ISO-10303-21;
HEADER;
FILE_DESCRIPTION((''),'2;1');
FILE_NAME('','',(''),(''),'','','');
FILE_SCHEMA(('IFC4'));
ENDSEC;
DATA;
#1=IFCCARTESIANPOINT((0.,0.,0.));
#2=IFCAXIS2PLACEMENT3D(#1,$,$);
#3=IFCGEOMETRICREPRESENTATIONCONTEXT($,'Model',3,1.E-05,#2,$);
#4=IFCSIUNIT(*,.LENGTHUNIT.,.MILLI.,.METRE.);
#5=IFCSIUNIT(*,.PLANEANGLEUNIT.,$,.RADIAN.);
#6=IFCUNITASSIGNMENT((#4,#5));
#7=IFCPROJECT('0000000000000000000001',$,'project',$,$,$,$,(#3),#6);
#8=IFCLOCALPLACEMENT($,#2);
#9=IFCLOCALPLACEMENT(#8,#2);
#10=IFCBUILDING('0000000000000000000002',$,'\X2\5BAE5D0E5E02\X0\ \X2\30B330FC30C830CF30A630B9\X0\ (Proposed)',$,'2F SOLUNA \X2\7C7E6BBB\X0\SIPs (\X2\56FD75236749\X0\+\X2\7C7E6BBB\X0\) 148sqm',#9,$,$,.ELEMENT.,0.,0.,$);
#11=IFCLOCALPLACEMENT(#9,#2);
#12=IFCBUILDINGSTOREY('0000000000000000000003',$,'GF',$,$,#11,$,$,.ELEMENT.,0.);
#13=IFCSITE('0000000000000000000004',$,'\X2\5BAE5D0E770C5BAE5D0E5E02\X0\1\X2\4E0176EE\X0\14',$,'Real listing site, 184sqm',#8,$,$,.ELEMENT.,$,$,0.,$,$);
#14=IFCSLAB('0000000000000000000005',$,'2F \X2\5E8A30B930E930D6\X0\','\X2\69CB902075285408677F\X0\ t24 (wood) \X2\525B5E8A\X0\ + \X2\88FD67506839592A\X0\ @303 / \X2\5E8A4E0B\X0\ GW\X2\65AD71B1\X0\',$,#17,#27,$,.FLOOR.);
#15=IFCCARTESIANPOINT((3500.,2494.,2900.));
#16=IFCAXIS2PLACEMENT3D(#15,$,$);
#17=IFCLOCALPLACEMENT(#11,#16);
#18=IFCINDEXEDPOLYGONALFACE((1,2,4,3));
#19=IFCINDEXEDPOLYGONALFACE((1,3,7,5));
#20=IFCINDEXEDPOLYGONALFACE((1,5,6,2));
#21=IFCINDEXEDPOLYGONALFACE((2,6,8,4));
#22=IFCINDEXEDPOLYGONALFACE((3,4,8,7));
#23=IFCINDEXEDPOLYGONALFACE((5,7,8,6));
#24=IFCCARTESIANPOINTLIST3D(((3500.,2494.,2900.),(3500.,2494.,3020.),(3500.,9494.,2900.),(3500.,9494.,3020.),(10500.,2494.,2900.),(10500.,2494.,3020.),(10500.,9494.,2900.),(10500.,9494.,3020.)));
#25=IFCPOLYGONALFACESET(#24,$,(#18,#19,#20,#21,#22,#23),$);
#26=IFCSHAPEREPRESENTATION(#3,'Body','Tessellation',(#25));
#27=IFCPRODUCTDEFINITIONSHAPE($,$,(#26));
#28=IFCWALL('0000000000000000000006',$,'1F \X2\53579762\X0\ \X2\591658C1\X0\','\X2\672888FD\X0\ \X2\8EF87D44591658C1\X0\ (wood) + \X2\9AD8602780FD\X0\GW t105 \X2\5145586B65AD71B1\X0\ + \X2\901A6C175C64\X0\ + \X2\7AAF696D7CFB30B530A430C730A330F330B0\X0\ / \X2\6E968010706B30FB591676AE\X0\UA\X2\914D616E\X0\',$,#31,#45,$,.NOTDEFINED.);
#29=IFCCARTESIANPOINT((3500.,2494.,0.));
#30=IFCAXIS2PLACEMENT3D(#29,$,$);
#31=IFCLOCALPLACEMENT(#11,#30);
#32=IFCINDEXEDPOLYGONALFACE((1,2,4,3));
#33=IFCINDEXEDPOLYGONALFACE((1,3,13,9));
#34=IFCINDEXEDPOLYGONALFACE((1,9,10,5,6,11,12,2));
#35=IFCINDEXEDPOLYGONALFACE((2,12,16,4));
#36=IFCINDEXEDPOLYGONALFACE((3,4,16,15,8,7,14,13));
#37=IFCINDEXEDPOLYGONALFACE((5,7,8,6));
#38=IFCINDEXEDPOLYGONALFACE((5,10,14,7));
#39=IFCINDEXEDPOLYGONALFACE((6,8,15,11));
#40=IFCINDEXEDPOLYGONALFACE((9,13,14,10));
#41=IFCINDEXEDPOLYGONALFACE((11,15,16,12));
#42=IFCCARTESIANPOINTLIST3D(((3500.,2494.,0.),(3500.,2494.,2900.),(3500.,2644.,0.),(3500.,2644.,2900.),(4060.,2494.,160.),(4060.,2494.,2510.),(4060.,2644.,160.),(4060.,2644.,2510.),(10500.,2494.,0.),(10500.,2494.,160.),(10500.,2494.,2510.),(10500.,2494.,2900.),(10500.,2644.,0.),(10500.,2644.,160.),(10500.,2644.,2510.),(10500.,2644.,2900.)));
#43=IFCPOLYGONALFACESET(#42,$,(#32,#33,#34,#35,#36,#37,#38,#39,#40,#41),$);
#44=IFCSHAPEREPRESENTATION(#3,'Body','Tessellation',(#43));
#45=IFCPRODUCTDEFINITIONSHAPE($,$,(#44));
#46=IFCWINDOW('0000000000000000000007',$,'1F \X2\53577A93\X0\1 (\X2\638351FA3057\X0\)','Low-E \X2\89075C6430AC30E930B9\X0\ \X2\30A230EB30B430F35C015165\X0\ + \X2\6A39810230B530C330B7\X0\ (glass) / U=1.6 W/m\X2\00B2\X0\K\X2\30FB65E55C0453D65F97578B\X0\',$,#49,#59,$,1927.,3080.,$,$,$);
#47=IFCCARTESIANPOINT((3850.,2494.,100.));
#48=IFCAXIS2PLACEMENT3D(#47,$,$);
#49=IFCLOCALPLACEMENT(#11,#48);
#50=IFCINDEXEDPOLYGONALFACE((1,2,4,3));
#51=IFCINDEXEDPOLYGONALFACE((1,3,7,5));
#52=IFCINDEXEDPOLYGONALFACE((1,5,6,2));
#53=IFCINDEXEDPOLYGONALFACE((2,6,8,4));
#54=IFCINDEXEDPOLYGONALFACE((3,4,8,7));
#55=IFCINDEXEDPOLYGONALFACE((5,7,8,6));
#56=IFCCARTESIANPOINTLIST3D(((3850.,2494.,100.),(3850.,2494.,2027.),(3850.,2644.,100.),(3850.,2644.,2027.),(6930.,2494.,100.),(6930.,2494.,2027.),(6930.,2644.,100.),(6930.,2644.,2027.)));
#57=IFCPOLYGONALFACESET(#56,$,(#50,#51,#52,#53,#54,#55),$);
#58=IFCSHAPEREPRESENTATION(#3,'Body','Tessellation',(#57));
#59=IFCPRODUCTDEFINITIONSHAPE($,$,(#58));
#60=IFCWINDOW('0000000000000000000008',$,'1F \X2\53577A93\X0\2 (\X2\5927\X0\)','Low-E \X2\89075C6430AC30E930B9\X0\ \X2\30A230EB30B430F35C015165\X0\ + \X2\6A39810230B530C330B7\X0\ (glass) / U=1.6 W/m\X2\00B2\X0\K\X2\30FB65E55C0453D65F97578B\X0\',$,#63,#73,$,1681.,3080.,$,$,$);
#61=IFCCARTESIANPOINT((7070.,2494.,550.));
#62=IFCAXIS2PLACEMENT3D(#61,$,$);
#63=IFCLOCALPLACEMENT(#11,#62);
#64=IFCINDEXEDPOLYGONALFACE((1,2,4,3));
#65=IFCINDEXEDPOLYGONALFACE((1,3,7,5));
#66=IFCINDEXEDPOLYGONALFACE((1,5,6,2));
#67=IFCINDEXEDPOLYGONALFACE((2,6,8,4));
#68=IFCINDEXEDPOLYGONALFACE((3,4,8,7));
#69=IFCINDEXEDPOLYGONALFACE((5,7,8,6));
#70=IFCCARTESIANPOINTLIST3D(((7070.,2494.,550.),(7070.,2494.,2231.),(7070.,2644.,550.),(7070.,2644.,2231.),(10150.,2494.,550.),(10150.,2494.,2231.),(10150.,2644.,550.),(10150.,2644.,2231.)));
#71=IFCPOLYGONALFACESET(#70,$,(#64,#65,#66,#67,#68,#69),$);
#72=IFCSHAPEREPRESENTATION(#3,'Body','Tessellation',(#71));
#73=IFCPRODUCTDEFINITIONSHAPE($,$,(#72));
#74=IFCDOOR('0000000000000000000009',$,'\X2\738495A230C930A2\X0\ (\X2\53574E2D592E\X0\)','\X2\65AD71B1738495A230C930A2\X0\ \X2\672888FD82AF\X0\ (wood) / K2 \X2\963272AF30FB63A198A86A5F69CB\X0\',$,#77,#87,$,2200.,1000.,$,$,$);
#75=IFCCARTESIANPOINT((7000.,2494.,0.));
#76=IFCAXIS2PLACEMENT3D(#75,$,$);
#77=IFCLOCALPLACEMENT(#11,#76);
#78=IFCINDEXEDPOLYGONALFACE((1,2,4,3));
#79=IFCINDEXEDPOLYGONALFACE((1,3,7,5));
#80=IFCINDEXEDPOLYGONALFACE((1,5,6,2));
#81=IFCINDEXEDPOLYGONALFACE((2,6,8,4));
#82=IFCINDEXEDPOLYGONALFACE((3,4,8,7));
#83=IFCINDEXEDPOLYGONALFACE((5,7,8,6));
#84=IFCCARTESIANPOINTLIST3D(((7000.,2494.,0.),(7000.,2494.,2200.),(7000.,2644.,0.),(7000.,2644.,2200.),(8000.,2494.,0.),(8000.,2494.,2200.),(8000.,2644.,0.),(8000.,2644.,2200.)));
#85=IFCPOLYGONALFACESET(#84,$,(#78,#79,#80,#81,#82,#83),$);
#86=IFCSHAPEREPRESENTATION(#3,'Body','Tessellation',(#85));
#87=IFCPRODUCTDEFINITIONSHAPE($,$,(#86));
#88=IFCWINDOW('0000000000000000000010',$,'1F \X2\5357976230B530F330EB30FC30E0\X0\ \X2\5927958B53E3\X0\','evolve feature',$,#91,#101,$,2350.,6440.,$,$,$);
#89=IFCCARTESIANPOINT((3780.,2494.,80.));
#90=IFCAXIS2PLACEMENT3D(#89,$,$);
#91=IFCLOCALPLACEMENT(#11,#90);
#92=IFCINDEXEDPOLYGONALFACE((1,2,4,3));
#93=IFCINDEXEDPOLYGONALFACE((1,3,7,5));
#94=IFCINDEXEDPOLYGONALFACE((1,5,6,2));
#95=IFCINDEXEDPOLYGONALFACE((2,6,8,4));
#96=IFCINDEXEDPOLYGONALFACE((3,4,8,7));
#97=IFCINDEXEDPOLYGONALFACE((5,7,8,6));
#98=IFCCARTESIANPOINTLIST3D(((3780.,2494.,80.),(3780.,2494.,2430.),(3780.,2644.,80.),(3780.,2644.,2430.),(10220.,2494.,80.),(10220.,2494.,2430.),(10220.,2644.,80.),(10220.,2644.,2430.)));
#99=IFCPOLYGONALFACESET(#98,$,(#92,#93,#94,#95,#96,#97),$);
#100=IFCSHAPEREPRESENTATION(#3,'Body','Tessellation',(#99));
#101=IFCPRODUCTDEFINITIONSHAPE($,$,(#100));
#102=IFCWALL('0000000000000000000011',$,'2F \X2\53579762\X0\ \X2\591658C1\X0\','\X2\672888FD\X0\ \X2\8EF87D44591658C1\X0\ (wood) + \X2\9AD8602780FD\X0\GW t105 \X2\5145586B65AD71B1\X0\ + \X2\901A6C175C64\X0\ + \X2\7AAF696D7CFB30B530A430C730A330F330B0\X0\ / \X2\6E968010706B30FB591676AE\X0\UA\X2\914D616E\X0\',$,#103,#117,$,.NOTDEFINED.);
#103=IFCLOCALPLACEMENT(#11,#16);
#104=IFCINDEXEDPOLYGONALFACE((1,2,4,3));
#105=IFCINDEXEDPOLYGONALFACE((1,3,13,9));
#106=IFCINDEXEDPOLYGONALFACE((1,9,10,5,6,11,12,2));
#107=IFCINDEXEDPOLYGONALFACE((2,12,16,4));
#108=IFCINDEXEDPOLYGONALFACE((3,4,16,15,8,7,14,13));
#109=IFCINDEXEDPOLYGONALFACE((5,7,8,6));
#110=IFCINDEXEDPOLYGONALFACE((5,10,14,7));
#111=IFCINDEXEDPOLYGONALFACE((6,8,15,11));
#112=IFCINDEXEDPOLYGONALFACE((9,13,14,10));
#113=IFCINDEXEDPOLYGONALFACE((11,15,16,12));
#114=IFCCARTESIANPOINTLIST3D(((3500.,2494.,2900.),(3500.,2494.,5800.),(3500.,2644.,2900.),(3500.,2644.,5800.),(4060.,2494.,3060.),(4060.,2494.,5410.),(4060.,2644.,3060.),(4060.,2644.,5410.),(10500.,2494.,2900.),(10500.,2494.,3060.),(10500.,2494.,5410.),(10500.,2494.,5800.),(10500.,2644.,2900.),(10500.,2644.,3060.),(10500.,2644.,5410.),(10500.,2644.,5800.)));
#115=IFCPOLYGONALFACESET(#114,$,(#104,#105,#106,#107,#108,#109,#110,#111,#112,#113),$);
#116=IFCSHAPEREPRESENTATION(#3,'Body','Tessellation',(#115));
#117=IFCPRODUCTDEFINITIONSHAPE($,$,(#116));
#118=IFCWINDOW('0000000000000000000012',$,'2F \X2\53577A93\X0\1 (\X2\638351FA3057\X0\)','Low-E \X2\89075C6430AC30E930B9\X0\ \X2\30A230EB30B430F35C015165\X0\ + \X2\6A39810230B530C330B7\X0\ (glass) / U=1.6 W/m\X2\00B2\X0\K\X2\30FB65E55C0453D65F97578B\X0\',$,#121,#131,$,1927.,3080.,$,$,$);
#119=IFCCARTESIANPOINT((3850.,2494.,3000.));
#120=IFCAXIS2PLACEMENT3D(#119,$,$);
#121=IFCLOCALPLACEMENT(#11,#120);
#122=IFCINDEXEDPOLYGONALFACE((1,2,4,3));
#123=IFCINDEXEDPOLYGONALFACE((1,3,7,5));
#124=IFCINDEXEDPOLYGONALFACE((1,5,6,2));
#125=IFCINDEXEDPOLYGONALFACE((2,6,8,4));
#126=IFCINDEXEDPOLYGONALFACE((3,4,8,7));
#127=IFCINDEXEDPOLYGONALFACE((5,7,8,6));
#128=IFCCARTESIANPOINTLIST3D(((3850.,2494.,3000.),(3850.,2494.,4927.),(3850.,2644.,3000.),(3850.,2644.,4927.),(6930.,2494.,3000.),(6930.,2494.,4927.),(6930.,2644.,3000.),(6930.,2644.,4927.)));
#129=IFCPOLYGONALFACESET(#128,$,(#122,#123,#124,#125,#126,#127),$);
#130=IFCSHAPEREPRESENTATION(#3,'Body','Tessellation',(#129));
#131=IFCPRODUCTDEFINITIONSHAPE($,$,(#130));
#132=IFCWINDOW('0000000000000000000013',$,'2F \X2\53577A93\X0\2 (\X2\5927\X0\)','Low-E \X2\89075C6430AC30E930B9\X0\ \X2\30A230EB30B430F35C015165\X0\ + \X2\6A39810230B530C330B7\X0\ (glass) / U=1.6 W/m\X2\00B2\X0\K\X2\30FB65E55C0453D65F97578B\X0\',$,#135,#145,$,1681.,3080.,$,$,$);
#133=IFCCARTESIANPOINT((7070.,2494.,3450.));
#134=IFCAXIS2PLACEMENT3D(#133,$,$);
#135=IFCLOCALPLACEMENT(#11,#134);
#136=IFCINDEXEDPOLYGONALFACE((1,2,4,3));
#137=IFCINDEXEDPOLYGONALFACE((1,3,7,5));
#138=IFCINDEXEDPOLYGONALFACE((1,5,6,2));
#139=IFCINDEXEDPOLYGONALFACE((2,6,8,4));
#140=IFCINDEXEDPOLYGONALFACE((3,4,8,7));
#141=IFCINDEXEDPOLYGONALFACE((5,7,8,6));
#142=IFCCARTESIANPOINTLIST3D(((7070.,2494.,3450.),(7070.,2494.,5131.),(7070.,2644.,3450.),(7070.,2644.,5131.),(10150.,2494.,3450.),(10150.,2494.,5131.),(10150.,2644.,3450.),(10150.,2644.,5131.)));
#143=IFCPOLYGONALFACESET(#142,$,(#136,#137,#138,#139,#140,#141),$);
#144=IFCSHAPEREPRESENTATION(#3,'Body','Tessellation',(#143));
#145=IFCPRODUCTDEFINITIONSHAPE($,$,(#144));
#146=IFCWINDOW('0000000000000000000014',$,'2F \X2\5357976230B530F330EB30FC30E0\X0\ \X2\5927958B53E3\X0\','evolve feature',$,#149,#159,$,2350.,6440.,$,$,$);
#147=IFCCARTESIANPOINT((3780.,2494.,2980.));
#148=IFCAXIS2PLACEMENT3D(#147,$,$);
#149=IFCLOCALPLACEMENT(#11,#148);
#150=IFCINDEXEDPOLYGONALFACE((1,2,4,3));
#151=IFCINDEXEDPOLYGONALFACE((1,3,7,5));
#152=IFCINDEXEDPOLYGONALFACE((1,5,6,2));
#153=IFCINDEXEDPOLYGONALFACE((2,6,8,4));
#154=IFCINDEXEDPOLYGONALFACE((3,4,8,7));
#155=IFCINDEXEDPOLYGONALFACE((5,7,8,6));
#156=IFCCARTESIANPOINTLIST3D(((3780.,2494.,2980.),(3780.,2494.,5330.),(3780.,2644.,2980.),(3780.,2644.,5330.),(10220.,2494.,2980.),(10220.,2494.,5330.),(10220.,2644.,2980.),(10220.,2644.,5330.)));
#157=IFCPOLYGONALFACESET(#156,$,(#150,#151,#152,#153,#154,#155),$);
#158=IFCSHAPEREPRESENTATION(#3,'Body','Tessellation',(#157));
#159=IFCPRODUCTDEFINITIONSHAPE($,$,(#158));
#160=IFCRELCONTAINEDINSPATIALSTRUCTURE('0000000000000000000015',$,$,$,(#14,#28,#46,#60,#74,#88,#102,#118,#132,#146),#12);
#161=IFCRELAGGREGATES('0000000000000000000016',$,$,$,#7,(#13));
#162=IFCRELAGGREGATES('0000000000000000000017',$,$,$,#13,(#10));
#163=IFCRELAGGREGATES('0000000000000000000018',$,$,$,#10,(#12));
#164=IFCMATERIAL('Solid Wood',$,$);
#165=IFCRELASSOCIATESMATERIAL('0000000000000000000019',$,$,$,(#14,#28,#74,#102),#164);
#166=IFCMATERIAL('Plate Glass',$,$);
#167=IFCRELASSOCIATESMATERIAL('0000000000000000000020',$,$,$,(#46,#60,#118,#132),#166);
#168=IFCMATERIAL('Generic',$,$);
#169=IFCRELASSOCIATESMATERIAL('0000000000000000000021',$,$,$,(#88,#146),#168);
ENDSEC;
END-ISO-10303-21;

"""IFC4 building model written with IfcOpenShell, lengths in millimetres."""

from ifc_helpers import new_model, si_unit, frame, frame_2d, origin, place, context, project, spatial, rectangle, extrude, material, element, fill, save


model = new_model("IFC4")

# Units and contexts
model_context = context("Model", 3, precision=1e-05, world=origin())
ifc_project = project(units=[si_unit("LENGTHUNIT", "METRE", prefix="MILLI"), si_unit("PLANEANGLEUNIT", "RADIAN")], contexts=[model_context])

# Site, building, storey
site_placement = place(None, origin())
site = spatial("IfcSite", under=ifc_project, at=site_placement, Name="宮崎県宮崎市1丁目14", ObjectType="Real listing site, 184sqm", CompositionType="ELEMENT", RefElevation=0.0)
building_placement = place(site_placement, origin())
building = spatial("IfcBuilding", under=site, at=building_placement, Name="宮崎市 コートハウス (Proposed)", ObjectType="2F SOLUNA 籾殻SIPs (国産杉+籾殻) 148sqm", CompositionType="ELEMENT", ElevationOfRefHeight=0.0, ElevationOfTerrain=0.0)
storey_placement = place(building_placement, origin())
storey = spatial("IfcBuildingStorey", under=building, at=storey_placement, Name="GF", CompositionType="ELEMENT", Elevation=0.0)

# Slab
ifc_material_1 = material(Name="Solid Wood")
slab_1_placement = place(storey_placement, frame((3500.0, 2494.0, 2900.0)))
element("IfcSlab", 1, at=slab_1_placement, inside=storey, material=ifc_material_1, Name="2F 床スラブ", Description="構造用合板 t24 (wood) 剛床 + 製材根太 @303 / 床下 GW断熱", PredefinedType="FLOOR", context=model_context, shape_type="SweptSolid", body=[
    extrude(rectangle(XDim=7000.0, YDim=7000.0, at=frame_2d((3500.0, 3500.0))), frame((3500.0, 2494.0, 2900.0)), (0.0, 0.0, 1.0), 120.0),
])
ifc_material_2 = material(Name="Generic")

# Wall, openings, windows, door
wall_1_placement = place(storey_placement, frame((3500.0, 2494.0, 0.0)))
wall_1 = element("IfcWall", 2, at=wall_1_placement, inside=storey, material=ifc_material_1, Name="1F 南面 外壁", Description="木製 軸組外壁 (wood) + 高性能GW t105 充填断熱 + 通気層 + 窯業系サイディング / 準耐火・外皮UA配慮", PredefinedType="NOTDEFINED", context=model_context, shape_type="SweptSolid", body=[
    extrude(rectangle(XDim=7000.0, YDim=150.0, at=frame_2d((3500.0, 75.0))), frame((3500.0, 2494.0, 0.0)), (0.0, 0.0, 1.0), 2900.0),
])
opening_1_placement = place(storey_placement, frame((3850.0, 2494.0, 100.0)))
opening_1 = element("IfcOpeningElement", 3, at=opening_1_placement, cuts=wall_1, PredefinedType="NOTDEFINED", context=model_context, shape_type="SweptSolid", body=[
    extrude(rectangle(XDim=3080.0, YDim=150.0, at=frame_2d((1540.0, 75.0))), frame((3850.0, 2494.0, 100.0)), (0.0, 0.0, 1.0), 1927.0),
])
opening_2_placement = place(storey_placement, frame((7070.0, 2494.0, 550.0)))
opening_2 = element("IfcOpeningElement", 4, at=opening_2_placement, cuts=wall_1, PredefinedType="NOTDEFINED", context=model_context, shape_type="SweptSolid", body=[
    extrude(rectangle(XDim=3080.0, YDim=150.0, at=frame_2d((1540.0, 75.0))), frame((7070.0, 2494.0, 550.0)), (0.0, 0.0, 1.0), 1681.0),
])
opening_3_placement = place(storey_placement, frame((7000.0, 2494.0, 0.0)))
opening_3 = element("IfcOpeningElement", 5, at=opening_3_placement, cuts=wall_1, PredefinedType="NOTDEFINED", context=model_context, shape_type="SweptSolid", body=[
    extrude(rectangle(XDim=1000.0, YDim=150.0, at=frame_2d((500.0, 75.0))), frame((7000.0, 2494.0, 0.0)), (0.0, 0.0, 1.0), 2200.0),
])
opening_4_placement = place(storey_placement, frame((3780.0, 2494.0, 80.0)))
opening_4 = element("IfcOpeningElement", 6, at=opening_4_placement, cuts=wall_1, PredefinedType="NOTDEFINED", context=model_context, shape_type="SweptSolid", body=[
    extrude(rectangle(XDim=6440.0, YDim=150.0, at=frame_2d((3220.0, 75.0))), frame((3780.0, 2494.0, 80.0)), (0.0, 0.0, 1.0), 2350.0),
])
ifc_material_3 = material(Name="Plate Glass")
window_1_placement = place(storey_placement, frame((3850.0, 2494.0, 100.0)))
window_1 = element("IfcWindow", 7, at=window_1_placement, inside=storey, material=ifc_material_3, Name="1F 南窓1 (掃出し)", Description="Low-E 複層ガラス アルゴン封入 + 樹脂サッシ (glass) / U=1.6 W/m²K・日射取得型", OverallHeight=1927.0, OverallWidth=3080.0, context=model_context, shape_type="SweptSolid", body=[
    extrude(rectangle(XDim=3080.0, YDim=150.0, at=frame_2d((1540.0, 75.0))), frame((3850.0, 2494.0, 100.0)), (0.0, 0.0, 1.0), 1927.0),
])
fill(opening_1, window_1)
window_2_placement = place(storey_placement, frame((7070.0, 2494.0, 550.0)))
window_2 = element("IfcWindow", 8, at=window_2_placement, inside=storey, material=ifc_material_3, Name="1F 南窓2 (大)", Description="Low-E 複層ガラス アルゴン封入 + 樹脂サッシ (glass) / U=1.6 W/m²K・日射取得型", OverallHeight=1681.0, OverallWidth=3080.0, context=model_context, shape_type="SweptSolid", body=[
    extrude(rectangle(XDim=3080.0, YDim=150.0, at=frame_2d((1540.0, 75.0))), frame((7070.0, 2494.0, 550.0)), (0.0, 0.0, 1.0), 1681.0),
])
fill(opening_2, window_2)
door_placement = place(storey_placement, frame((7000.0, 2494.0, 0.0)))
door = element("IfcDoor", 9, at=door_placement, inside=storey, material=ifc_material_1, Name="玄関ドア (南中央)", Description="断熱玄関ドア 木製芯 (wood) / K2 防犯・採風機構", OverallHeight=2200.0, OverallWidth=1000.0, context=model_context, shape_type="SweptSolid", body=[
    extrude(rectangle(XDim=1000.0, YDim=150.0, at=frame_2d((500.0, 75.0))), frame((7000.0, 2494.0, 0.0)), (0.0, 0.0, 1.0), 2200.0),
])
fill(opening_3, door)
window_3_placement = place(storey_placement, frame((3780.0, 2494.0, 80.0)))
window_3 = element("IfcWindow", 10, at=window_3_placement, inside=storey, material=ifc_material_2, Name="1F 南面サンルーム 大開口", Description="evolve feature", OverallHeight=2350.0, OverallWidth=6440.0, context=model_context, shape_type="SweptSolid", body=[
    extrude(rectangle(XDim=6440.0, YDim=150.0, at=frame_2d((3220.0, 75.0))), frame((3780.0, 2494.0, 80.0)), (0.0, 0.0, 1.0), 2350.0),
])
fill(opening_4, window_3)

# Wall, openings, windows
wall_2_placement = place(storey_placement, frame((3500.0, 2494.0, 2900.0)))
wall_2 = element("IfcWall", 11, at=wall_2_placement, inside=storey, material=ifc_material_1, Name="2F 南面 外壁", Description="木製 軸組外壁 (wood) + 高性能GW t105 充填断熱 + 通気層 + 窯業系サイディング / 準耐火・外皮UA配慮", PredefinedType="NOTDEFINED", context=model_context, shape_type="SweptSolid", body=[
    extrude(rectangle(XDim=7000.0, YDim=150.0, at=frame_2d((3500.0, 75.0))), frame((3500.0, 2494.0, 2900.0)), (0.0, 0.0, 1.0), 2900.0),
])
opening_5_placement = place(storey_placement, frame((3850.0, 2494.0, 3000.0)))
opening_5 = element("IfcOpeningElement", 12, at=opening_5_placement, cuts=wall_2, PredefinedType="NOTDEFINED", context=model_context, shape_type="SweptSolid", body=[
    extrude(rectangle(XDim=3080.0, YDim=150.0, at=frame_2d((1540.0, 75.0))), frame((3850.0, 2494.0, 3000.0)), (0.0, 0.0, 1.0), 1927.0),
])
opening_6_placement = place(storey_placement, frame((7070.0, 2494.0, 3450.0)))
opening_6 = element("IfcOpeningElement", 13, at=opening_6_placement, cuts=wall_2, PredefinedType="NOTDEFINED", context=model_context, shape_type="SweptSolid", body=[
    extrude(rectangle(XDim=3080.0, YDim=150.0, at=frame_2d((1540.0, 75.0))), frame((7070.0, 2494.0, 3450.0)), (0.0, 0.0, 1.0), 1681.0),
])
opening_7_placement = place(storey_placement, frame((3780.0, 2494.0, 2980.0)))
opening_7 = element("IfcOpeningElement", 14, at=opening_7_placement, cuts=wall_2, PredefinedType="NOTDEFINED", context=model_context, shape_type="SweptSolid", body=[
    extrude(rectangle(XDim=6440.0, YDim=150.0, at=frame_2d((3220.0, 75.0))), frame((3780.0, 2494.0, 2980.0)), (0.0, 0.0, 1.0), 2350.0),
])
window_4_placement = place(storey_placement, frame((3850.0, 2494.0, 3000.0)))
window_4 = element("IfcWindow", 15, at=window_4_placement, inside=storey, material=ifc_material_3, Name="2F 南窓1 (掃出し)", Description="Low-E 複層ガラス アルゴン封入 + 樹脂サッシ (glass) / U=1.6 W/m²K・日射取得型", OverallHeight=1927.0, OverallWidth=3080.0, context=model_context, shape_type="SweptSolid", body=[
    extrude(rectangle(XDim=3080.0, YDim=150.0, at=frame_2d((1540.0, 75.0))), frame((3850.0, 2494.0, 3000.0)), (0.0, 0.0, 1.0), 1927.0),
])
fill(opening_5, window_4)
window_5_placement = place(storey_placement, frame((7070.0, 2494.0, 3450.0)))
window_5 = element("IfcWindow", 16, at=window_5_placement, inside=storey, material=ifc_material_3, Name="2F 南窓2 (大)", Description="Low-E 複層ガラス アルゴン封入 + 樹脂サッシ (glass) / U=1.6 W/m²K・日射取得型", OverallHeight=1681.0, OverallWidth=3080.0, context=model_context, shape_type="SweptSolid", body=[
    extrude(rectangle(XDim=3080.0, YDim=150.0, at=frame_2d((1540.0, 75.0))), frame((7070.0, 2494.0, 3450.0)), (0.0, 0.0, 1.0), 1681.0),
])
fill(opening_6, window_5)
window_6_placement = place(storey_placement, frame((3780.0, 2494.0, 2980.0)))
window_6 = element("IfcWindow", 17, at=window_6_placement, inside=storey, material=ifc_material_2, Name="2F 南面サンルーム 大開口", Description="evolve feature", OverallHeight=2350.0, OverallWidth=6440.0, context=model_context, shape_type="SweptSolid", body=[
    extrude(rectangle(XDim=6440.0, YDim=150.0, at=frame_2d((3220.0, 75.0))), frame((3780.0, 2494.0, 2980.0)), (0.0, 0.0, 1.0), 2350.0),
])
fill(opening_7, window_6)

save(model, "model.ifc")
